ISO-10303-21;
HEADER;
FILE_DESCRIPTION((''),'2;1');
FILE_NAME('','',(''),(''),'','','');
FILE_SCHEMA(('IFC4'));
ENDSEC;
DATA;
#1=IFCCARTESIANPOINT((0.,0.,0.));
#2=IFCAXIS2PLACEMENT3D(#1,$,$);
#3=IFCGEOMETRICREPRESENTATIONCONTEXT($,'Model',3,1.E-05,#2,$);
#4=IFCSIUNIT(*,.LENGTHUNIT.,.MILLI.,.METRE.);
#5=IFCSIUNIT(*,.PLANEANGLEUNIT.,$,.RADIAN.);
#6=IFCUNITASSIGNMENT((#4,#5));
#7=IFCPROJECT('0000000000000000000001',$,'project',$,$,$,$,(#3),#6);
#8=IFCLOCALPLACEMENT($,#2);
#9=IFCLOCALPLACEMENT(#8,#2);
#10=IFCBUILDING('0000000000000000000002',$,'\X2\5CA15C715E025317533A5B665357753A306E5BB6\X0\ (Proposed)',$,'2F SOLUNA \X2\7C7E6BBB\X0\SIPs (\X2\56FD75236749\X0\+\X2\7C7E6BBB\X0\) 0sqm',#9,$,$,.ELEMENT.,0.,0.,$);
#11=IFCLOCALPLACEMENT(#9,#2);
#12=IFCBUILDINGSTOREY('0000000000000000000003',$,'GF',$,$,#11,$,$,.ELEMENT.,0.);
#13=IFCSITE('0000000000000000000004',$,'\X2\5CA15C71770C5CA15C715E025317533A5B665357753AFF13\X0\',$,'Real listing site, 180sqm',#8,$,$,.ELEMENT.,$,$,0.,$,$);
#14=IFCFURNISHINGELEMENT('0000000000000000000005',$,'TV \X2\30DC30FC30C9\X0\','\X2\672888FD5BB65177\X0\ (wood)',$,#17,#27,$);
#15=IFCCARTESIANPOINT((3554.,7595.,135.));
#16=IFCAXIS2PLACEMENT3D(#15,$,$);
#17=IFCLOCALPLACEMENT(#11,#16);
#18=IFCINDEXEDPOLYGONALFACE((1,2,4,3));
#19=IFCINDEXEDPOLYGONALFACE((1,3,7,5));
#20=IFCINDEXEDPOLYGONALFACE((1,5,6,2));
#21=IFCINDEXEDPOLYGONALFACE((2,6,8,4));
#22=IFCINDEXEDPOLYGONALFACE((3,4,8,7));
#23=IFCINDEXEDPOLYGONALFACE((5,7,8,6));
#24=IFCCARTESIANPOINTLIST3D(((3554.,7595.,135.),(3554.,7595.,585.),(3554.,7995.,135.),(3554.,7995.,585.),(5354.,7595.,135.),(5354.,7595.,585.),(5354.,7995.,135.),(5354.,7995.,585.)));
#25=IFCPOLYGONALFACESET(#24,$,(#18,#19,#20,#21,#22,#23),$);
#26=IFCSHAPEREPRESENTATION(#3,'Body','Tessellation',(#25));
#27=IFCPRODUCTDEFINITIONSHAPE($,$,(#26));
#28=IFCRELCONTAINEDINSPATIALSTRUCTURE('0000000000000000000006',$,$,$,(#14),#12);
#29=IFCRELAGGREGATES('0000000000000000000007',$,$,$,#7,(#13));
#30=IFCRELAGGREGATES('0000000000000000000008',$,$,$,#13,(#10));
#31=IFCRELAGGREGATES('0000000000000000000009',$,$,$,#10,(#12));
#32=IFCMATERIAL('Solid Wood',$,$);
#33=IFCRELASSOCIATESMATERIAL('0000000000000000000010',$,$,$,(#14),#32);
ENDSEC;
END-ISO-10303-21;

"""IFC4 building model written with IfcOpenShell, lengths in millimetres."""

from ifc_helpers import new_model, si_unit, frame, frame_2d, origin, place, context, project, spatial, rectangle, extrude, material, element, save


model = new_model("IFC4")

# Units and contexts
model_context = context("Model", 3, precision=1e-05, world=origin())
ifc_project = project(units=[si_unit("LENGTHUNIT", "METRE", prefix="MILLI"), si_unit("PLANEANGLEUNIT", "RADIAN")], contexts=[model_context])

# Site, building, storey
site_placement = place(None, origin())
site = spatial("IfcSite", under=ifc_project, at=site_placement, Name="岡山県岡山市北区学南町３", ObjectType="Real listing site, 180sqm", CompositionType="ELEMENT", RefElevation=0.0)
building_placement = place(site_placement, origin())
building = spatial("IfcBuilding", under=site, at=building_placement, Name="岡山市北区学南町の家 (Proposed)", ObjectType="2F SOLUNA 籾殻SIPs (国産杉+籾殻) 0sqm", CompositionType="ELEMENT", ElevationOfRefHeight=0.0, ElevationOfTerrain=0.0)
storey_placement = place(building_placement, origin())
storey = spatial("IfcBuildingStorey", under=building, at=storey_placement, Name="GF", CompositionType="ELEMENT", Elevation=0.0)

# Shared definitions
ifc_material_1 = material(Name="Solid Wood")

# Furnishing element
furnishing_1_placement = place(storey_placement, frame((3554.0, 7595.0, 135.0)))
element("IfcFurnishingElement", 1, at=furnishing_1_placement, inside=storey, material=ifc_material_1, Name="TV ボード", Description="木製家具 (wood)", context=model_context, shape_type="SweptSolid", body=[
    extrude(rectangle(XDim=1800.0, YDim=400.0, at=frame_2d((900.0, 200.0))), frame((3554.0, 7595.0, 135.0)), (0.0, 0.0, 1.0), 450.0),
])

save(model, "model.ifc")
